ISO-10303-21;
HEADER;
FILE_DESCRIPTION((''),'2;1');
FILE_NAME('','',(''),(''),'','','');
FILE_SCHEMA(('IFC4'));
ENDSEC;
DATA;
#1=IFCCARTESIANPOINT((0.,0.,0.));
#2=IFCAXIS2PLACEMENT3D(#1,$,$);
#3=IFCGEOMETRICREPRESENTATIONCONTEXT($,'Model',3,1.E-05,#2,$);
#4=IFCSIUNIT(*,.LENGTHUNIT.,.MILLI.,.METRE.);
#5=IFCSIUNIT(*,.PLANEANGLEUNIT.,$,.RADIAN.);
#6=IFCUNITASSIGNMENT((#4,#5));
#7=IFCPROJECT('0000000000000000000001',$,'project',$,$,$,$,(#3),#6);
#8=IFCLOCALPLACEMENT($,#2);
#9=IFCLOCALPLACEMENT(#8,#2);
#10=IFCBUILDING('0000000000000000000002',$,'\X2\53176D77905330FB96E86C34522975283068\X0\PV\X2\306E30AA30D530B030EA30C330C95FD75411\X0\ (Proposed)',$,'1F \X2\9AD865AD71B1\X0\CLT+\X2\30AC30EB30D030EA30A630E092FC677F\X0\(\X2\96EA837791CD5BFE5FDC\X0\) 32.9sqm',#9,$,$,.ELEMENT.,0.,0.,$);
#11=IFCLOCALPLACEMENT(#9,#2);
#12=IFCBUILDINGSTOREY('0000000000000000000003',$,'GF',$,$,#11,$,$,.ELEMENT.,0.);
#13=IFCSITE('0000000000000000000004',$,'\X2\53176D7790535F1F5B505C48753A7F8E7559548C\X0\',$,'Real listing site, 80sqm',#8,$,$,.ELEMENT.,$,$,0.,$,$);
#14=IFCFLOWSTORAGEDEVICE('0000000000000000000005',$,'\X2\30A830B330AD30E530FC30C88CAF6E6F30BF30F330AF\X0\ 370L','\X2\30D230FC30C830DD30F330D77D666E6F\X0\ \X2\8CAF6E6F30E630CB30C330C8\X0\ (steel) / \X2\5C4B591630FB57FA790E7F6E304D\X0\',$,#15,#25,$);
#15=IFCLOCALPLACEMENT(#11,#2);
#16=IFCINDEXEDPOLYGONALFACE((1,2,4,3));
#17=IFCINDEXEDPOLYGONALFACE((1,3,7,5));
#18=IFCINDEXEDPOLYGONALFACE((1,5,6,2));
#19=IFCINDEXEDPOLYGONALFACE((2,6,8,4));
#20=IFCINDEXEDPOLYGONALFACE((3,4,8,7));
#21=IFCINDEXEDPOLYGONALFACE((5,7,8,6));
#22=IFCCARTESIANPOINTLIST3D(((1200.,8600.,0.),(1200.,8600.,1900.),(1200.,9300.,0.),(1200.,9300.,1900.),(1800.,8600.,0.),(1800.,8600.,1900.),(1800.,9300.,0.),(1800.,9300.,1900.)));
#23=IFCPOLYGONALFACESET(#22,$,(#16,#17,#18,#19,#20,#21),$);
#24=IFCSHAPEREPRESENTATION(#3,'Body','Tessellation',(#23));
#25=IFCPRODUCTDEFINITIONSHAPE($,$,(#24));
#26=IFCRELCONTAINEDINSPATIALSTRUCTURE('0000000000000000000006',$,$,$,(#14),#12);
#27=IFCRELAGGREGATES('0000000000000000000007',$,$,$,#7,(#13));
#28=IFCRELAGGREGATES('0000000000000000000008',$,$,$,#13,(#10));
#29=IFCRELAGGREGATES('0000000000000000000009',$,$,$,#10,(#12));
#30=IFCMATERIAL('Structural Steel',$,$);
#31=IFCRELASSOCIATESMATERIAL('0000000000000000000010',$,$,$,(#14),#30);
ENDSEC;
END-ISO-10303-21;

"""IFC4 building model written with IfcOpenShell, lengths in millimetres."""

from ifc_helpers import new_model, si_unit, frame, frame_2d, origin, place, context, project, spatial, rectangle, extrude, material, element, save


model = new_model("IFC4")

# Units and contexts
model_context = context("Model", 3, precision=1e-05, world=origin())
ifc_project = project(units=[si_unit("LENGTHUNIT", "METRE", prefix="MILLI"), si_unit("PLANEANGLEUNIT", "RADIAN")], contexts=[model_context])

# Site, building, storey
site_placement = place(None, origin())
site = spatial("IfcSite", under=ifc_project, at=site_placement, Name="北海道弟子屈町美留和", ObjectType="Real listing site, 80sqm", CompositionType="ELEMENT", RefElevation=0.0)
building_placement = place(site_placement, origin())
building = spatial("IfcBuilding", under=site, at=building_placement, Name="北海道・雨水利用とPVのオフグリッド志向 (Proposed)", ObjectType="1F 高断熱CLT+ガルバリウム鋼板(雪荷重対応) 32.9sqm", CompositionType="ELEMENT", ElevationOfRefHeight=0.0, ElevationOfTerrain=0.0)
storey_placement = place(building_placement, origin())
storey = spatial("IfcBuildingStorey", under=building, at=storey_placement, Name="GF", CompositionType="ELEMENT", Elevation=0.0)

# Shared definitions
ifc_material_1 = material(Name="Structural Steel")

# Flow storage device
flow_storage_device_placement = place(storey_placement, frame((600.0, 4300.0, 0.0)))
element("IfcFlowStorageDevice", 1, at=flow_storage_device_placement, inside=storey, material=ifc_material_1, Name="エコキュート貯湯タンク 370L", Description="ヒートポンプ給湯 貯湯ユニット (steel) / 屋外・基礎置き", context=model_context, shape_type="SweptSolid", body=[
    extrude(rectangle(XDim=600.0, YDim=700.0, at=frame_2d((300.0, 350.0))), frame((600.0, 4300.0, 0.0)), (0.0, 0.0, 1.0), 1900.0),
])

save(model, "model.ifc")
